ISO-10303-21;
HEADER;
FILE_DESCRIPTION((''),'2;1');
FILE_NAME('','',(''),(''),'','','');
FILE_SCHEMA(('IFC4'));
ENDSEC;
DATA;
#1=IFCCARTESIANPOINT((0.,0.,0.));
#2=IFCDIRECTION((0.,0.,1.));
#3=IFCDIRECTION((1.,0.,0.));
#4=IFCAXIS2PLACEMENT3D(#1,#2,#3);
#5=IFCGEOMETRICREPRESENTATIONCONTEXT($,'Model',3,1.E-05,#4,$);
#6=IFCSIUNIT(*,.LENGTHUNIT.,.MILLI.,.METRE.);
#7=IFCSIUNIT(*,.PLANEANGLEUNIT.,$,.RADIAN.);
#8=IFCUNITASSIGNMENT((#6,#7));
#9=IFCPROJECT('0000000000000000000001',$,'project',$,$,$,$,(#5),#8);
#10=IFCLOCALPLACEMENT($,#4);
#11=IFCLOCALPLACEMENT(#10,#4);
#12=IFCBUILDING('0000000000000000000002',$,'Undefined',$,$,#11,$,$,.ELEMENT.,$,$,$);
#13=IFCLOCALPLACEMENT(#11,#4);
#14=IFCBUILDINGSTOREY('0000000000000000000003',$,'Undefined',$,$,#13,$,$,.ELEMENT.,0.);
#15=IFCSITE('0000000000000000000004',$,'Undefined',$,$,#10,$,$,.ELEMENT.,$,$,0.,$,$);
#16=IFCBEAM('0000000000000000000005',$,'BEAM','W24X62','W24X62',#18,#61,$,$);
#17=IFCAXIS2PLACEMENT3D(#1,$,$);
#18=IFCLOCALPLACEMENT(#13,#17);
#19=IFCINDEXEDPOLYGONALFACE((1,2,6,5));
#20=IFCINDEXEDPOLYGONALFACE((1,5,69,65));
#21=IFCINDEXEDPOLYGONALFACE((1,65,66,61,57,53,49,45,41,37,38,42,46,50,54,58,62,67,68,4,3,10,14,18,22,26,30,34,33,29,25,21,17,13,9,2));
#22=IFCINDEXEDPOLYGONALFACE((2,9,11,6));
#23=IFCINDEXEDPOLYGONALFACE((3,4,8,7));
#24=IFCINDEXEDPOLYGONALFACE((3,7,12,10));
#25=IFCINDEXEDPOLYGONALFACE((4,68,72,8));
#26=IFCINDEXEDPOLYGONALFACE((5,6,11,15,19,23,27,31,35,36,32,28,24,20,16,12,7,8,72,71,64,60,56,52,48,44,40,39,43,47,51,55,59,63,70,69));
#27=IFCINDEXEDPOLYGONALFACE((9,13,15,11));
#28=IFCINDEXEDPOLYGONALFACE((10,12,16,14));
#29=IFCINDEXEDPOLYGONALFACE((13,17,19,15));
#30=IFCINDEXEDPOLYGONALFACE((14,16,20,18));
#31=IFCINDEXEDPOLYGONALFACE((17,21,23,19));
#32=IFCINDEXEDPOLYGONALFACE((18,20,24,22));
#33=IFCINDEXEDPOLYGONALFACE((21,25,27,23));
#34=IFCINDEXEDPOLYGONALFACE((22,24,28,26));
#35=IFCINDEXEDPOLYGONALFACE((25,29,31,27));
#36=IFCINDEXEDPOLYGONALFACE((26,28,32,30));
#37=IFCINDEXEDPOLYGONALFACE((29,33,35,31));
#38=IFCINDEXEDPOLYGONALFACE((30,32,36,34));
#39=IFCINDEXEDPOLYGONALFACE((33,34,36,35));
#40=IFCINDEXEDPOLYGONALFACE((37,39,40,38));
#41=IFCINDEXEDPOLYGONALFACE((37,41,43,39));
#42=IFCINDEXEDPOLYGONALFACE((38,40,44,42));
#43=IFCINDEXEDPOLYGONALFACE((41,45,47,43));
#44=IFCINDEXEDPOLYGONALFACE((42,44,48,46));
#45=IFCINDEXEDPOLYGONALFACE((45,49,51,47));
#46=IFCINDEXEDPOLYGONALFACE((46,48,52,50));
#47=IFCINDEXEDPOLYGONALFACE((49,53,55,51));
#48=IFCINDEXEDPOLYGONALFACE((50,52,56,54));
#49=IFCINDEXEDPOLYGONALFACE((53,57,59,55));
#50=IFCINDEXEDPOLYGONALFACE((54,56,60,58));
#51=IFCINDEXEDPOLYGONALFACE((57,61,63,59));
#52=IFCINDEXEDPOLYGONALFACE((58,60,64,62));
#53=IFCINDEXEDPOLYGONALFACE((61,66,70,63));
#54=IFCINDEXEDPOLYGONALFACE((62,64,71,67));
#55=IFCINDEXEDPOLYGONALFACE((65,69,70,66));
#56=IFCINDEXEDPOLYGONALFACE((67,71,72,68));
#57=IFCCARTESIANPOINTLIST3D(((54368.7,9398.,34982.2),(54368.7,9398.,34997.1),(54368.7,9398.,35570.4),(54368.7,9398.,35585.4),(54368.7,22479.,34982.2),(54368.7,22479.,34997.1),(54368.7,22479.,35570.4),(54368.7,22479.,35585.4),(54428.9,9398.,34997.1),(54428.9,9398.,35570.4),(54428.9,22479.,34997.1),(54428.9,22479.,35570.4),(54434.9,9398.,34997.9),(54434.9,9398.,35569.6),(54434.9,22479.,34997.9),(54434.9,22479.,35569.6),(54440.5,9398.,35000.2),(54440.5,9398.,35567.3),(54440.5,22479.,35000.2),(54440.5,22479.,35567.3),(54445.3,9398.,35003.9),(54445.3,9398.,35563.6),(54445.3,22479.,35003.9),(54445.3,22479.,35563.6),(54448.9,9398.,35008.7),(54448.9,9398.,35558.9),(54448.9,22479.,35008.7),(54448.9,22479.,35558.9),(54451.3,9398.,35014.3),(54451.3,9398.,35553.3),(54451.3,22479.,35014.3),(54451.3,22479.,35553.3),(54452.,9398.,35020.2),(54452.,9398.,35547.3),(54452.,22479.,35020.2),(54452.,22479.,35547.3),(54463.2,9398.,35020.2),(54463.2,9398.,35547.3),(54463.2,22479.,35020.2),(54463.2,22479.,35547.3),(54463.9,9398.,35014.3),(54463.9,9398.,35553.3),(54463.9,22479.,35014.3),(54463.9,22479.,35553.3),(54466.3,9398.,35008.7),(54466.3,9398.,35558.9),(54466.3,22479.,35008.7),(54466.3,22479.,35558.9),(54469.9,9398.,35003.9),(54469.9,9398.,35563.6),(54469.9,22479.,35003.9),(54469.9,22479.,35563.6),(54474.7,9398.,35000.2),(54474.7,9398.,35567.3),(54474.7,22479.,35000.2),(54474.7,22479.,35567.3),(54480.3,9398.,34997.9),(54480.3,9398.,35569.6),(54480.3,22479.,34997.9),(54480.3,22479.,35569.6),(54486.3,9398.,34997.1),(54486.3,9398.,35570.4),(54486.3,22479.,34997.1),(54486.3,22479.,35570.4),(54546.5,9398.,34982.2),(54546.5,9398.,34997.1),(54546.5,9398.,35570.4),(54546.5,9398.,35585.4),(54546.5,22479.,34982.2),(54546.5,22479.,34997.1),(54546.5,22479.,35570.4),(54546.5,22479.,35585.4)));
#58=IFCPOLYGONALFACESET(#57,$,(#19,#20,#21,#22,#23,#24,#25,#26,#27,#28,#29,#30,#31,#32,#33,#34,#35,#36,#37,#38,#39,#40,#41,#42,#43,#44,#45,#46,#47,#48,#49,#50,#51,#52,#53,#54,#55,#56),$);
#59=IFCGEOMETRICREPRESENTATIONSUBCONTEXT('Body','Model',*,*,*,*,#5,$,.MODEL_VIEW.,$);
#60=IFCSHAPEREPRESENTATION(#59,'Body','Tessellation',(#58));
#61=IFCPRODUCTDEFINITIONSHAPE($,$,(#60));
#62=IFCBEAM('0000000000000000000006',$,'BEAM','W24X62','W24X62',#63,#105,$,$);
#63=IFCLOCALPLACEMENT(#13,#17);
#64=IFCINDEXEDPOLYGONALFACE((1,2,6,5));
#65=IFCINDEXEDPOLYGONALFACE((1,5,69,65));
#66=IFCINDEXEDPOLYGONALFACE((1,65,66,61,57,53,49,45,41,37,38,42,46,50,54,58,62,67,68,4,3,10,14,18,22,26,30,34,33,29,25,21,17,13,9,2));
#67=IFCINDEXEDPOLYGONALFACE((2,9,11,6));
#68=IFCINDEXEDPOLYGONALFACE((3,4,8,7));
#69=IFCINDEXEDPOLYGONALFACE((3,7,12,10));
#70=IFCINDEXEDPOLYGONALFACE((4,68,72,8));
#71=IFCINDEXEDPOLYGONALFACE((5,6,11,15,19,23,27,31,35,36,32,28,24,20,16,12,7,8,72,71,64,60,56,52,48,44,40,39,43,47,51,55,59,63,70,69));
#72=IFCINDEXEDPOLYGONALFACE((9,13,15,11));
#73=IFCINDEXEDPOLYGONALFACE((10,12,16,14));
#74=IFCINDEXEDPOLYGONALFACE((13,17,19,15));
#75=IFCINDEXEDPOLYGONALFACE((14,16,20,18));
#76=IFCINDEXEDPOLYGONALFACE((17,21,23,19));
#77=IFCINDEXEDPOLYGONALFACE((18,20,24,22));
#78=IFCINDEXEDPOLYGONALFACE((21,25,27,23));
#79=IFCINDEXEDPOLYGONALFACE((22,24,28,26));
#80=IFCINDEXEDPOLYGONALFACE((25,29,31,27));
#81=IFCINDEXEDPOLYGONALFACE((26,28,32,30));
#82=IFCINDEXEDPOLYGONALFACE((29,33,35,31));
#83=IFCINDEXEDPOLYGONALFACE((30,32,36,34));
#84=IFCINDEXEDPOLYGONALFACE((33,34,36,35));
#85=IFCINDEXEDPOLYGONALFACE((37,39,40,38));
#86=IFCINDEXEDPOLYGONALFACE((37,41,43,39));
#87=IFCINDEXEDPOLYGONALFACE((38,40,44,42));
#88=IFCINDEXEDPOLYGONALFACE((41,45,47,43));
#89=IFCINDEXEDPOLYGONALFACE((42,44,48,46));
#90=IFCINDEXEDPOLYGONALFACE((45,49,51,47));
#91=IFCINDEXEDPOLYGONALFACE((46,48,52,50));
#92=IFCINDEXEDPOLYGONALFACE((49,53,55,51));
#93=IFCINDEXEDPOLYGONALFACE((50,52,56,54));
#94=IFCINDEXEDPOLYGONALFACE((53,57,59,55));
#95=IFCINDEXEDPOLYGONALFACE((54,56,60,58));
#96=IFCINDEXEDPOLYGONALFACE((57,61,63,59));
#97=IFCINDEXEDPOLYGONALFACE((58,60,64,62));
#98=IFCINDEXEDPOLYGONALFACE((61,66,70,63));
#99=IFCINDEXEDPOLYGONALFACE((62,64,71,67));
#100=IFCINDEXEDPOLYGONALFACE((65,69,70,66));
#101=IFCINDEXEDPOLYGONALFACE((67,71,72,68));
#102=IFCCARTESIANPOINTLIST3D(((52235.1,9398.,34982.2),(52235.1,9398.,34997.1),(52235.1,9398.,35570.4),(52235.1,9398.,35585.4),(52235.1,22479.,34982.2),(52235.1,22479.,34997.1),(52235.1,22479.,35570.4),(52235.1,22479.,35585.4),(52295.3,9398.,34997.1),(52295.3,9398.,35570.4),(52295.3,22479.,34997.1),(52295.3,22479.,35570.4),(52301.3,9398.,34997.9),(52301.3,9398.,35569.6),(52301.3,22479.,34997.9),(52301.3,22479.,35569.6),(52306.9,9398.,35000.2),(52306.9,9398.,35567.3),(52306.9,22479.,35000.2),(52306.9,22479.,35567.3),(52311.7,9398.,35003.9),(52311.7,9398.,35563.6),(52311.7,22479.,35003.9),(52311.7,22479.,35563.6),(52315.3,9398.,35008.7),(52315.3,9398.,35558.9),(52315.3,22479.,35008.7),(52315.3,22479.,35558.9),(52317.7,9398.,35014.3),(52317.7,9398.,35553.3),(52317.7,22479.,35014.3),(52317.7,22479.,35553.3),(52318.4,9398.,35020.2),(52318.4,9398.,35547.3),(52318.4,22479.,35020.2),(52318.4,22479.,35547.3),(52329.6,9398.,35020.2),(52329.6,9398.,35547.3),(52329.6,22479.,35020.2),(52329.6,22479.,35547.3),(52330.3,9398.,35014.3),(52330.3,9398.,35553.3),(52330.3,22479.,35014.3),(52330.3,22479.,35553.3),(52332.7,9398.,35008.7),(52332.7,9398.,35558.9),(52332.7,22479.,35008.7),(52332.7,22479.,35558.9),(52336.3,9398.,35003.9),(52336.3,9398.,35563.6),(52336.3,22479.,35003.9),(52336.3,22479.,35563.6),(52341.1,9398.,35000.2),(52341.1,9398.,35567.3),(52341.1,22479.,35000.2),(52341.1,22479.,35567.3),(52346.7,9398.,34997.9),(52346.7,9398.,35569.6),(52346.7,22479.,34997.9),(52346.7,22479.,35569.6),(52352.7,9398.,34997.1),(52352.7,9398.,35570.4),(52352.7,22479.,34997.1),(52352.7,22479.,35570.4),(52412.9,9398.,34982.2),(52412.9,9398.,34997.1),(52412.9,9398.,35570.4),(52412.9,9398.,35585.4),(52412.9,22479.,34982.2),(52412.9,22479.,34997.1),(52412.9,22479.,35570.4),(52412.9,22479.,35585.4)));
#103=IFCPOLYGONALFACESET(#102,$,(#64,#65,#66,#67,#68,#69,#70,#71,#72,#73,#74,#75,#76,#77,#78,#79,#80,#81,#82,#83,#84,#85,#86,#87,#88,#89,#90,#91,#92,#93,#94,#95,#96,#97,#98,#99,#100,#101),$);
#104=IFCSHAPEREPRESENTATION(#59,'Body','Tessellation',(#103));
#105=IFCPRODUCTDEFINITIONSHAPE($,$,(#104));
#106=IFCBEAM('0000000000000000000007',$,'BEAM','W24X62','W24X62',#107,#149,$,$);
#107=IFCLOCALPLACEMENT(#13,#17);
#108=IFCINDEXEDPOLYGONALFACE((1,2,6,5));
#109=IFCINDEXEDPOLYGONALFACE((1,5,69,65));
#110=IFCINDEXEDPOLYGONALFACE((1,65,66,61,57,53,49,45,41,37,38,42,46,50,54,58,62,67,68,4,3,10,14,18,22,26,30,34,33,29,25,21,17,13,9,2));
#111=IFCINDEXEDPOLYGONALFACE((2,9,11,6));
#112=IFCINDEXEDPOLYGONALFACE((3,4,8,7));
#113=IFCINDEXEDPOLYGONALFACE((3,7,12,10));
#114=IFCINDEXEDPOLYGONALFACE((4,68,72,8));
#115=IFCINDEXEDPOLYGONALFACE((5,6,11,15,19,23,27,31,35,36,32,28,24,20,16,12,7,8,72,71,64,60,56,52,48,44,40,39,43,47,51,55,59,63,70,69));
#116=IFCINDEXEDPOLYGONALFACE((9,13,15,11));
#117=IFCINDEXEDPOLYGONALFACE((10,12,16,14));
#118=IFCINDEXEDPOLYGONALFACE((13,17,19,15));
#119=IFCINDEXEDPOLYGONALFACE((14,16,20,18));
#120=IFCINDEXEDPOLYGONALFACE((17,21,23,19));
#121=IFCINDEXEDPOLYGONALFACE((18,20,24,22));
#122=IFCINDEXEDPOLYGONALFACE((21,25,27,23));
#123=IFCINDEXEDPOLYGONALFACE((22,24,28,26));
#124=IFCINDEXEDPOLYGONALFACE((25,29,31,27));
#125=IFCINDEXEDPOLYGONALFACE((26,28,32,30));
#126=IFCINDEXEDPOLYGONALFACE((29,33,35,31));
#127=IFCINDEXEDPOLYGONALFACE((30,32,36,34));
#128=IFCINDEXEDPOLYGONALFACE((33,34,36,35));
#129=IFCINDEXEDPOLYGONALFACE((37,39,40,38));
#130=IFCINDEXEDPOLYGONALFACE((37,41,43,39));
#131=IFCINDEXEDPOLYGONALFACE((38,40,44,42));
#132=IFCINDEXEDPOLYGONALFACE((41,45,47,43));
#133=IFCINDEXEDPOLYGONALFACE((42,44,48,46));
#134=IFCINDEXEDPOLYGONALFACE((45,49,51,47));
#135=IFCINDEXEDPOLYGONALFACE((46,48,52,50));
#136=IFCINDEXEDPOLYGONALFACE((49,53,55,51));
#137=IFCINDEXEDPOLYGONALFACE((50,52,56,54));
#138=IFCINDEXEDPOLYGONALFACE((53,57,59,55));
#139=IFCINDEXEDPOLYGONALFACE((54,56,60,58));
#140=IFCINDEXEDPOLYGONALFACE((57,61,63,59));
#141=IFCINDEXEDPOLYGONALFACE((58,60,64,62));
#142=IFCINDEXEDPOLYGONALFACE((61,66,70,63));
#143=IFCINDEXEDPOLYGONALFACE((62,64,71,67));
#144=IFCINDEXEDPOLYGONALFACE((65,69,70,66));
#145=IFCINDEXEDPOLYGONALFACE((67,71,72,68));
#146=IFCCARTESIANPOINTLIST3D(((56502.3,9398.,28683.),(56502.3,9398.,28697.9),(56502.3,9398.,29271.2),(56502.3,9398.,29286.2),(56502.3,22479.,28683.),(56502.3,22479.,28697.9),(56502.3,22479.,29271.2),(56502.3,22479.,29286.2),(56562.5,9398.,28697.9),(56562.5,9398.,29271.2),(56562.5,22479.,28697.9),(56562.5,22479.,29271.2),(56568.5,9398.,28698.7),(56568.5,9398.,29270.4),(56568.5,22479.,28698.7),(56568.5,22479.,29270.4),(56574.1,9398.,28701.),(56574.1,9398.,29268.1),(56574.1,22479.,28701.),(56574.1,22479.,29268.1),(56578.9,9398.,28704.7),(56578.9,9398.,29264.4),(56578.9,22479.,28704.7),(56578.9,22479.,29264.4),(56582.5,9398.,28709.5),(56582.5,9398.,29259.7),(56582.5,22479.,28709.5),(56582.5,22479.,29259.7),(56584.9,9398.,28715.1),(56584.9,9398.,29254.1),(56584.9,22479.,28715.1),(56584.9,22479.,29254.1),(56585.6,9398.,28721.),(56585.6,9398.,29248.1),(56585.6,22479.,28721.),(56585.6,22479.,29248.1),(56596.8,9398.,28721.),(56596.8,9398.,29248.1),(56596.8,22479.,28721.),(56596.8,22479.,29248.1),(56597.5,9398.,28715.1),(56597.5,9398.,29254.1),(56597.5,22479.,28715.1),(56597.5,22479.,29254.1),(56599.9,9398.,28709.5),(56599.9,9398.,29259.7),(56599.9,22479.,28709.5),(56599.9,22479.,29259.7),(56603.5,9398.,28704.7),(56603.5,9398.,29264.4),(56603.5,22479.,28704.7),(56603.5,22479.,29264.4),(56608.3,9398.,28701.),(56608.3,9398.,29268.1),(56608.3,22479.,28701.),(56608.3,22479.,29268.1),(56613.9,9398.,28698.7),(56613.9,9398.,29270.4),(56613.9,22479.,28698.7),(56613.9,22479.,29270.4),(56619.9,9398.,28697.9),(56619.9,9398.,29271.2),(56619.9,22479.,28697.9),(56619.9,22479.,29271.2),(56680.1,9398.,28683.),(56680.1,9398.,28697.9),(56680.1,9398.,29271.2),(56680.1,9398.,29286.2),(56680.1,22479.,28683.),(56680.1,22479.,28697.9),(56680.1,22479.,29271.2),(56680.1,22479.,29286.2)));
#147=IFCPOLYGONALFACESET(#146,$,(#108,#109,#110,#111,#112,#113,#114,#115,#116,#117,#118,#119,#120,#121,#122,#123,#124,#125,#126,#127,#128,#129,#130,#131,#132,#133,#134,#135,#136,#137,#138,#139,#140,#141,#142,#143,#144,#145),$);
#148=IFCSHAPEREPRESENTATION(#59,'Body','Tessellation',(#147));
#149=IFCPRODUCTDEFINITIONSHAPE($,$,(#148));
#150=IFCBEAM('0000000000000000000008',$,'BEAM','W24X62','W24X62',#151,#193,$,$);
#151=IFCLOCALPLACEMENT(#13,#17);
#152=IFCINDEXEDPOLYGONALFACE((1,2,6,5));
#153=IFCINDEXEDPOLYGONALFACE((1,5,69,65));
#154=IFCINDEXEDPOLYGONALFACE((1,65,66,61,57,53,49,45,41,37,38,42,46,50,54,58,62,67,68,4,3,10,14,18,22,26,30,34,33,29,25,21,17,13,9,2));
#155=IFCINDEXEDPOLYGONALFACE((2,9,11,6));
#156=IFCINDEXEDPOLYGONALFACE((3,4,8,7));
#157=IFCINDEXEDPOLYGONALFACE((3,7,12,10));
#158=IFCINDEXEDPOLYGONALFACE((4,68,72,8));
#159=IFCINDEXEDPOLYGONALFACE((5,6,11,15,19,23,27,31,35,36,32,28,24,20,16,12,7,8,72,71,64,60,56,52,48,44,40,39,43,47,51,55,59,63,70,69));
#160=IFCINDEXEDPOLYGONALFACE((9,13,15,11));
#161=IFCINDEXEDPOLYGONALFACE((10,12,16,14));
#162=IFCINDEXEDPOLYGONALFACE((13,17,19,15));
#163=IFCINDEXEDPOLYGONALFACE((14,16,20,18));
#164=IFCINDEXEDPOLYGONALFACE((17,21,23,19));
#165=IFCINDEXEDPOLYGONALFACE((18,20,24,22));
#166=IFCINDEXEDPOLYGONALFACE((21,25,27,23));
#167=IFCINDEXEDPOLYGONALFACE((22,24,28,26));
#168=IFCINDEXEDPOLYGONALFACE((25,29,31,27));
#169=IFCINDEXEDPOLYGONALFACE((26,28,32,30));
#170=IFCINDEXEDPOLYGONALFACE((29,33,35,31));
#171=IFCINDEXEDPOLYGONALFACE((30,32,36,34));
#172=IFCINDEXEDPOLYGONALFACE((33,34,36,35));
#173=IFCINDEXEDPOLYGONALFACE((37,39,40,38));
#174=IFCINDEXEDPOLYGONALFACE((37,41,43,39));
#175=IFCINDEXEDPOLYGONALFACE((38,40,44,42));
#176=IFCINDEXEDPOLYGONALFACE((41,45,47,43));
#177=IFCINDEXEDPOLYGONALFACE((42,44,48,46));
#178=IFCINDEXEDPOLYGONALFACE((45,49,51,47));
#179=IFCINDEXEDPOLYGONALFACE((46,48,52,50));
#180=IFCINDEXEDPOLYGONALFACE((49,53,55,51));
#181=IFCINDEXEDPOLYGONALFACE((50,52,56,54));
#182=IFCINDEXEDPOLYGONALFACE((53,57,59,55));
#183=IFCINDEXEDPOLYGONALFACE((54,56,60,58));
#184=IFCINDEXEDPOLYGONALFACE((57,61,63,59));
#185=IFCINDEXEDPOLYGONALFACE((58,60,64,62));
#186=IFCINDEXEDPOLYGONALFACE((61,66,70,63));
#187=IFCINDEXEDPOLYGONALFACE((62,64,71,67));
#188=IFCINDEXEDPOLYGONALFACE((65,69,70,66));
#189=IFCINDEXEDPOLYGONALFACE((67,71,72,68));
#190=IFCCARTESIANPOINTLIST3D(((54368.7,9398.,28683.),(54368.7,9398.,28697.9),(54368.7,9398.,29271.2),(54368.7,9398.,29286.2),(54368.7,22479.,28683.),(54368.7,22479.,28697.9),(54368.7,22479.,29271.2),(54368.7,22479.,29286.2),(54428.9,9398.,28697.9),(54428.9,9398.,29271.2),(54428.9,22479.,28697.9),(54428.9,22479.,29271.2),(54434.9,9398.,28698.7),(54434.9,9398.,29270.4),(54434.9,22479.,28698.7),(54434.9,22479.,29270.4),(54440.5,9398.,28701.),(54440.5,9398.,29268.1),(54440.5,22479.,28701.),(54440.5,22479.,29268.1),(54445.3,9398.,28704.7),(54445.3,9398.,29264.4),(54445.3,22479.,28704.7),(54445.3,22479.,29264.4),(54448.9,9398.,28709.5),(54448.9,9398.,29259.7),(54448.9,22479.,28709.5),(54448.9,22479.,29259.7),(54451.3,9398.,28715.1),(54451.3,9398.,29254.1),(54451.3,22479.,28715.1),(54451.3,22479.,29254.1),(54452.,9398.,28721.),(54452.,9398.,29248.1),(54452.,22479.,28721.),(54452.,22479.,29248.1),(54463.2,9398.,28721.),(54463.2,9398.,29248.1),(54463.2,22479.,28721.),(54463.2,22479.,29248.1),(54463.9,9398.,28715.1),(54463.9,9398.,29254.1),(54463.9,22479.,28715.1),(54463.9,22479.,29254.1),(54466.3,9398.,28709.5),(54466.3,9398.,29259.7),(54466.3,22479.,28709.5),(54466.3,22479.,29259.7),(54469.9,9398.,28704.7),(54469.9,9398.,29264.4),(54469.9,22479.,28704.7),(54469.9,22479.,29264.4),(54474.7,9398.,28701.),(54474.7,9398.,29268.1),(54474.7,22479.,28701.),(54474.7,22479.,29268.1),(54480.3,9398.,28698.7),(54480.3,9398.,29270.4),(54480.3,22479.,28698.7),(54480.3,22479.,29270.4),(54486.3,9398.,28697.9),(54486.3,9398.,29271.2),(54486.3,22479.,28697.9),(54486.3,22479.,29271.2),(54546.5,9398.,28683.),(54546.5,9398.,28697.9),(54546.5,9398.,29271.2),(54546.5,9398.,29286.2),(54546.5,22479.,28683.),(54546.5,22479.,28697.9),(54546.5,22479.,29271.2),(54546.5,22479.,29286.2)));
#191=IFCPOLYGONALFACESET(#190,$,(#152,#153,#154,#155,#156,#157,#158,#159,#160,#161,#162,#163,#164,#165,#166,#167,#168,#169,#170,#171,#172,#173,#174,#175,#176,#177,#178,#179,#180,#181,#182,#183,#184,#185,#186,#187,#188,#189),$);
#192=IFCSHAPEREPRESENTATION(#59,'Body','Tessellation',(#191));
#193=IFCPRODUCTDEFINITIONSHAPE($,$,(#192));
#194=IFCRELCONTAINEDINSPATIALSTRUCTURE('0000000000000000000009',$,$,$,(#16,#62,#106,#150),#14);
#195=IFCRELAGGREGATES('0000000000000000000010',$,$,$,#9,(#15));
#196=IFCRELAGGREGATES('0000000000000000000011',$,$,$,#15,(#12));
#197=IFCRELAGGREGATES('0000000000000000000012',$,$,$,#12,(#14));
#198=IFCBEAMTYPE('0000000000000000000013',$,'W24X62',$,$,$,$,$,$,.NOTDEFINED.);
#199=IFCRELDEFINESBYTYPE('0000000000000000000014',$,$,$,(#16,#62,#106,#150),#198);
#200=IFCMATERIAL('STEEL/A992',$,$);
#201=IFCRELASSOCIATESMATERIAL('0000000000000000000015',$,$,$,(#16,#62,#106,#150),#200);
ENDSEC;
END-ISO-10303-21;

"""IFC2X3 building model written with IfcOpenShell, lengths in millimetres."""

from ifc_helpers import new_model, si_unit, frame, origin_with_axes, origin_2d_with_axis, place, context, subcontext, project, spatial, i_section, extrude, material, type_object, element, save


model = new_model("IFC2X3")

# Units and contexts
model_context = context("Model", 3, precision=1e-05, world=origin_with_axes())
body_context = subcontext(model_context, "Body", "Model", "MODEL_VIEW")
ifc_project = project(units=[si_unit("LENGTHUNIT", "METRE", prefix="MILLI"), si_unit("PLANEANGLEUNIT", "RADIAN")], contexts=[model_context])

# Site, building, storey
site_placement = place(None, origin_with_axes())
site = spatial("IfcSite", under=ifc_project, at=site_placement, Name="Undefined", CompositionType="ELEMENT", RefElevation=0.0)
building_placement = place(site_placement, origin_with_axes())
building = spatial("IfcBuilding", under=site, at=building_placement, Name="Undefined", CompositionType="ELEMENT")
storey_placement = place(building_placement, origin_with_axes())
storey = spatial("IfcBuildingStorey", under=building, at=storey_placement, Name="Undefined", CompositionType="ELEMENT", Elevation=0.0)

# Shared definitions
ifc_material_1 = material(Name="STEEL/A992")

# Beams
beam_type_1 = type_object("IfcBeamType", Name="W24X62", PredefinedType="NOTDEFINED")
for number, where, z_axis, x_axis, name in (
    (1, (54457.6, 9398.0, 35283.8), (0.0, 0.0, 1.0), (0.0, 1.0, 0.0), "BEAM"),
    (2, (52324.0, 9398.0, 35283.8), (0.0, 0.0, 1.0), (0.0, 1.0, 0.0), "BEAM"),
    (3, (56591.2, 9398.0, 28984.6), (0.0, 0.0, 1.0), (0.0, 1.0, 0.0), "BEAM"),
    (4, (54457.6, 9398.0, 28984.6), (0.0, 0.0, 1.0), (0.0, 1.0, 0.0), "BEAM"),
):
    element("IfcBeam", number, at=place(storey_placement, frame(where, z_axis=z_axis, x_axis=x_axis)), inside=storey, type_object=beam_type_1, material=ifc_material_1, Name=name, Description="W24X62", ObjectType="W24X62", context=body_context, shape_type="SweptSolid", body=[
        extrude(i_section(OverallWidth=177.8, OverallDepth=603.2, WebThickness=11.1, FlangeThickness=15.0, FilletRadius=23.1, at=origin_2d_with_axis()), frame((13081.0, 0.0, 0.0), z_axis=(-1.0, 0.0, 0.0), x_axis=(0.0, -1.0, 0.0)), (0.0, 0.0, 1.0), 13081.0),
    ])

save(model, "model.ifc")
